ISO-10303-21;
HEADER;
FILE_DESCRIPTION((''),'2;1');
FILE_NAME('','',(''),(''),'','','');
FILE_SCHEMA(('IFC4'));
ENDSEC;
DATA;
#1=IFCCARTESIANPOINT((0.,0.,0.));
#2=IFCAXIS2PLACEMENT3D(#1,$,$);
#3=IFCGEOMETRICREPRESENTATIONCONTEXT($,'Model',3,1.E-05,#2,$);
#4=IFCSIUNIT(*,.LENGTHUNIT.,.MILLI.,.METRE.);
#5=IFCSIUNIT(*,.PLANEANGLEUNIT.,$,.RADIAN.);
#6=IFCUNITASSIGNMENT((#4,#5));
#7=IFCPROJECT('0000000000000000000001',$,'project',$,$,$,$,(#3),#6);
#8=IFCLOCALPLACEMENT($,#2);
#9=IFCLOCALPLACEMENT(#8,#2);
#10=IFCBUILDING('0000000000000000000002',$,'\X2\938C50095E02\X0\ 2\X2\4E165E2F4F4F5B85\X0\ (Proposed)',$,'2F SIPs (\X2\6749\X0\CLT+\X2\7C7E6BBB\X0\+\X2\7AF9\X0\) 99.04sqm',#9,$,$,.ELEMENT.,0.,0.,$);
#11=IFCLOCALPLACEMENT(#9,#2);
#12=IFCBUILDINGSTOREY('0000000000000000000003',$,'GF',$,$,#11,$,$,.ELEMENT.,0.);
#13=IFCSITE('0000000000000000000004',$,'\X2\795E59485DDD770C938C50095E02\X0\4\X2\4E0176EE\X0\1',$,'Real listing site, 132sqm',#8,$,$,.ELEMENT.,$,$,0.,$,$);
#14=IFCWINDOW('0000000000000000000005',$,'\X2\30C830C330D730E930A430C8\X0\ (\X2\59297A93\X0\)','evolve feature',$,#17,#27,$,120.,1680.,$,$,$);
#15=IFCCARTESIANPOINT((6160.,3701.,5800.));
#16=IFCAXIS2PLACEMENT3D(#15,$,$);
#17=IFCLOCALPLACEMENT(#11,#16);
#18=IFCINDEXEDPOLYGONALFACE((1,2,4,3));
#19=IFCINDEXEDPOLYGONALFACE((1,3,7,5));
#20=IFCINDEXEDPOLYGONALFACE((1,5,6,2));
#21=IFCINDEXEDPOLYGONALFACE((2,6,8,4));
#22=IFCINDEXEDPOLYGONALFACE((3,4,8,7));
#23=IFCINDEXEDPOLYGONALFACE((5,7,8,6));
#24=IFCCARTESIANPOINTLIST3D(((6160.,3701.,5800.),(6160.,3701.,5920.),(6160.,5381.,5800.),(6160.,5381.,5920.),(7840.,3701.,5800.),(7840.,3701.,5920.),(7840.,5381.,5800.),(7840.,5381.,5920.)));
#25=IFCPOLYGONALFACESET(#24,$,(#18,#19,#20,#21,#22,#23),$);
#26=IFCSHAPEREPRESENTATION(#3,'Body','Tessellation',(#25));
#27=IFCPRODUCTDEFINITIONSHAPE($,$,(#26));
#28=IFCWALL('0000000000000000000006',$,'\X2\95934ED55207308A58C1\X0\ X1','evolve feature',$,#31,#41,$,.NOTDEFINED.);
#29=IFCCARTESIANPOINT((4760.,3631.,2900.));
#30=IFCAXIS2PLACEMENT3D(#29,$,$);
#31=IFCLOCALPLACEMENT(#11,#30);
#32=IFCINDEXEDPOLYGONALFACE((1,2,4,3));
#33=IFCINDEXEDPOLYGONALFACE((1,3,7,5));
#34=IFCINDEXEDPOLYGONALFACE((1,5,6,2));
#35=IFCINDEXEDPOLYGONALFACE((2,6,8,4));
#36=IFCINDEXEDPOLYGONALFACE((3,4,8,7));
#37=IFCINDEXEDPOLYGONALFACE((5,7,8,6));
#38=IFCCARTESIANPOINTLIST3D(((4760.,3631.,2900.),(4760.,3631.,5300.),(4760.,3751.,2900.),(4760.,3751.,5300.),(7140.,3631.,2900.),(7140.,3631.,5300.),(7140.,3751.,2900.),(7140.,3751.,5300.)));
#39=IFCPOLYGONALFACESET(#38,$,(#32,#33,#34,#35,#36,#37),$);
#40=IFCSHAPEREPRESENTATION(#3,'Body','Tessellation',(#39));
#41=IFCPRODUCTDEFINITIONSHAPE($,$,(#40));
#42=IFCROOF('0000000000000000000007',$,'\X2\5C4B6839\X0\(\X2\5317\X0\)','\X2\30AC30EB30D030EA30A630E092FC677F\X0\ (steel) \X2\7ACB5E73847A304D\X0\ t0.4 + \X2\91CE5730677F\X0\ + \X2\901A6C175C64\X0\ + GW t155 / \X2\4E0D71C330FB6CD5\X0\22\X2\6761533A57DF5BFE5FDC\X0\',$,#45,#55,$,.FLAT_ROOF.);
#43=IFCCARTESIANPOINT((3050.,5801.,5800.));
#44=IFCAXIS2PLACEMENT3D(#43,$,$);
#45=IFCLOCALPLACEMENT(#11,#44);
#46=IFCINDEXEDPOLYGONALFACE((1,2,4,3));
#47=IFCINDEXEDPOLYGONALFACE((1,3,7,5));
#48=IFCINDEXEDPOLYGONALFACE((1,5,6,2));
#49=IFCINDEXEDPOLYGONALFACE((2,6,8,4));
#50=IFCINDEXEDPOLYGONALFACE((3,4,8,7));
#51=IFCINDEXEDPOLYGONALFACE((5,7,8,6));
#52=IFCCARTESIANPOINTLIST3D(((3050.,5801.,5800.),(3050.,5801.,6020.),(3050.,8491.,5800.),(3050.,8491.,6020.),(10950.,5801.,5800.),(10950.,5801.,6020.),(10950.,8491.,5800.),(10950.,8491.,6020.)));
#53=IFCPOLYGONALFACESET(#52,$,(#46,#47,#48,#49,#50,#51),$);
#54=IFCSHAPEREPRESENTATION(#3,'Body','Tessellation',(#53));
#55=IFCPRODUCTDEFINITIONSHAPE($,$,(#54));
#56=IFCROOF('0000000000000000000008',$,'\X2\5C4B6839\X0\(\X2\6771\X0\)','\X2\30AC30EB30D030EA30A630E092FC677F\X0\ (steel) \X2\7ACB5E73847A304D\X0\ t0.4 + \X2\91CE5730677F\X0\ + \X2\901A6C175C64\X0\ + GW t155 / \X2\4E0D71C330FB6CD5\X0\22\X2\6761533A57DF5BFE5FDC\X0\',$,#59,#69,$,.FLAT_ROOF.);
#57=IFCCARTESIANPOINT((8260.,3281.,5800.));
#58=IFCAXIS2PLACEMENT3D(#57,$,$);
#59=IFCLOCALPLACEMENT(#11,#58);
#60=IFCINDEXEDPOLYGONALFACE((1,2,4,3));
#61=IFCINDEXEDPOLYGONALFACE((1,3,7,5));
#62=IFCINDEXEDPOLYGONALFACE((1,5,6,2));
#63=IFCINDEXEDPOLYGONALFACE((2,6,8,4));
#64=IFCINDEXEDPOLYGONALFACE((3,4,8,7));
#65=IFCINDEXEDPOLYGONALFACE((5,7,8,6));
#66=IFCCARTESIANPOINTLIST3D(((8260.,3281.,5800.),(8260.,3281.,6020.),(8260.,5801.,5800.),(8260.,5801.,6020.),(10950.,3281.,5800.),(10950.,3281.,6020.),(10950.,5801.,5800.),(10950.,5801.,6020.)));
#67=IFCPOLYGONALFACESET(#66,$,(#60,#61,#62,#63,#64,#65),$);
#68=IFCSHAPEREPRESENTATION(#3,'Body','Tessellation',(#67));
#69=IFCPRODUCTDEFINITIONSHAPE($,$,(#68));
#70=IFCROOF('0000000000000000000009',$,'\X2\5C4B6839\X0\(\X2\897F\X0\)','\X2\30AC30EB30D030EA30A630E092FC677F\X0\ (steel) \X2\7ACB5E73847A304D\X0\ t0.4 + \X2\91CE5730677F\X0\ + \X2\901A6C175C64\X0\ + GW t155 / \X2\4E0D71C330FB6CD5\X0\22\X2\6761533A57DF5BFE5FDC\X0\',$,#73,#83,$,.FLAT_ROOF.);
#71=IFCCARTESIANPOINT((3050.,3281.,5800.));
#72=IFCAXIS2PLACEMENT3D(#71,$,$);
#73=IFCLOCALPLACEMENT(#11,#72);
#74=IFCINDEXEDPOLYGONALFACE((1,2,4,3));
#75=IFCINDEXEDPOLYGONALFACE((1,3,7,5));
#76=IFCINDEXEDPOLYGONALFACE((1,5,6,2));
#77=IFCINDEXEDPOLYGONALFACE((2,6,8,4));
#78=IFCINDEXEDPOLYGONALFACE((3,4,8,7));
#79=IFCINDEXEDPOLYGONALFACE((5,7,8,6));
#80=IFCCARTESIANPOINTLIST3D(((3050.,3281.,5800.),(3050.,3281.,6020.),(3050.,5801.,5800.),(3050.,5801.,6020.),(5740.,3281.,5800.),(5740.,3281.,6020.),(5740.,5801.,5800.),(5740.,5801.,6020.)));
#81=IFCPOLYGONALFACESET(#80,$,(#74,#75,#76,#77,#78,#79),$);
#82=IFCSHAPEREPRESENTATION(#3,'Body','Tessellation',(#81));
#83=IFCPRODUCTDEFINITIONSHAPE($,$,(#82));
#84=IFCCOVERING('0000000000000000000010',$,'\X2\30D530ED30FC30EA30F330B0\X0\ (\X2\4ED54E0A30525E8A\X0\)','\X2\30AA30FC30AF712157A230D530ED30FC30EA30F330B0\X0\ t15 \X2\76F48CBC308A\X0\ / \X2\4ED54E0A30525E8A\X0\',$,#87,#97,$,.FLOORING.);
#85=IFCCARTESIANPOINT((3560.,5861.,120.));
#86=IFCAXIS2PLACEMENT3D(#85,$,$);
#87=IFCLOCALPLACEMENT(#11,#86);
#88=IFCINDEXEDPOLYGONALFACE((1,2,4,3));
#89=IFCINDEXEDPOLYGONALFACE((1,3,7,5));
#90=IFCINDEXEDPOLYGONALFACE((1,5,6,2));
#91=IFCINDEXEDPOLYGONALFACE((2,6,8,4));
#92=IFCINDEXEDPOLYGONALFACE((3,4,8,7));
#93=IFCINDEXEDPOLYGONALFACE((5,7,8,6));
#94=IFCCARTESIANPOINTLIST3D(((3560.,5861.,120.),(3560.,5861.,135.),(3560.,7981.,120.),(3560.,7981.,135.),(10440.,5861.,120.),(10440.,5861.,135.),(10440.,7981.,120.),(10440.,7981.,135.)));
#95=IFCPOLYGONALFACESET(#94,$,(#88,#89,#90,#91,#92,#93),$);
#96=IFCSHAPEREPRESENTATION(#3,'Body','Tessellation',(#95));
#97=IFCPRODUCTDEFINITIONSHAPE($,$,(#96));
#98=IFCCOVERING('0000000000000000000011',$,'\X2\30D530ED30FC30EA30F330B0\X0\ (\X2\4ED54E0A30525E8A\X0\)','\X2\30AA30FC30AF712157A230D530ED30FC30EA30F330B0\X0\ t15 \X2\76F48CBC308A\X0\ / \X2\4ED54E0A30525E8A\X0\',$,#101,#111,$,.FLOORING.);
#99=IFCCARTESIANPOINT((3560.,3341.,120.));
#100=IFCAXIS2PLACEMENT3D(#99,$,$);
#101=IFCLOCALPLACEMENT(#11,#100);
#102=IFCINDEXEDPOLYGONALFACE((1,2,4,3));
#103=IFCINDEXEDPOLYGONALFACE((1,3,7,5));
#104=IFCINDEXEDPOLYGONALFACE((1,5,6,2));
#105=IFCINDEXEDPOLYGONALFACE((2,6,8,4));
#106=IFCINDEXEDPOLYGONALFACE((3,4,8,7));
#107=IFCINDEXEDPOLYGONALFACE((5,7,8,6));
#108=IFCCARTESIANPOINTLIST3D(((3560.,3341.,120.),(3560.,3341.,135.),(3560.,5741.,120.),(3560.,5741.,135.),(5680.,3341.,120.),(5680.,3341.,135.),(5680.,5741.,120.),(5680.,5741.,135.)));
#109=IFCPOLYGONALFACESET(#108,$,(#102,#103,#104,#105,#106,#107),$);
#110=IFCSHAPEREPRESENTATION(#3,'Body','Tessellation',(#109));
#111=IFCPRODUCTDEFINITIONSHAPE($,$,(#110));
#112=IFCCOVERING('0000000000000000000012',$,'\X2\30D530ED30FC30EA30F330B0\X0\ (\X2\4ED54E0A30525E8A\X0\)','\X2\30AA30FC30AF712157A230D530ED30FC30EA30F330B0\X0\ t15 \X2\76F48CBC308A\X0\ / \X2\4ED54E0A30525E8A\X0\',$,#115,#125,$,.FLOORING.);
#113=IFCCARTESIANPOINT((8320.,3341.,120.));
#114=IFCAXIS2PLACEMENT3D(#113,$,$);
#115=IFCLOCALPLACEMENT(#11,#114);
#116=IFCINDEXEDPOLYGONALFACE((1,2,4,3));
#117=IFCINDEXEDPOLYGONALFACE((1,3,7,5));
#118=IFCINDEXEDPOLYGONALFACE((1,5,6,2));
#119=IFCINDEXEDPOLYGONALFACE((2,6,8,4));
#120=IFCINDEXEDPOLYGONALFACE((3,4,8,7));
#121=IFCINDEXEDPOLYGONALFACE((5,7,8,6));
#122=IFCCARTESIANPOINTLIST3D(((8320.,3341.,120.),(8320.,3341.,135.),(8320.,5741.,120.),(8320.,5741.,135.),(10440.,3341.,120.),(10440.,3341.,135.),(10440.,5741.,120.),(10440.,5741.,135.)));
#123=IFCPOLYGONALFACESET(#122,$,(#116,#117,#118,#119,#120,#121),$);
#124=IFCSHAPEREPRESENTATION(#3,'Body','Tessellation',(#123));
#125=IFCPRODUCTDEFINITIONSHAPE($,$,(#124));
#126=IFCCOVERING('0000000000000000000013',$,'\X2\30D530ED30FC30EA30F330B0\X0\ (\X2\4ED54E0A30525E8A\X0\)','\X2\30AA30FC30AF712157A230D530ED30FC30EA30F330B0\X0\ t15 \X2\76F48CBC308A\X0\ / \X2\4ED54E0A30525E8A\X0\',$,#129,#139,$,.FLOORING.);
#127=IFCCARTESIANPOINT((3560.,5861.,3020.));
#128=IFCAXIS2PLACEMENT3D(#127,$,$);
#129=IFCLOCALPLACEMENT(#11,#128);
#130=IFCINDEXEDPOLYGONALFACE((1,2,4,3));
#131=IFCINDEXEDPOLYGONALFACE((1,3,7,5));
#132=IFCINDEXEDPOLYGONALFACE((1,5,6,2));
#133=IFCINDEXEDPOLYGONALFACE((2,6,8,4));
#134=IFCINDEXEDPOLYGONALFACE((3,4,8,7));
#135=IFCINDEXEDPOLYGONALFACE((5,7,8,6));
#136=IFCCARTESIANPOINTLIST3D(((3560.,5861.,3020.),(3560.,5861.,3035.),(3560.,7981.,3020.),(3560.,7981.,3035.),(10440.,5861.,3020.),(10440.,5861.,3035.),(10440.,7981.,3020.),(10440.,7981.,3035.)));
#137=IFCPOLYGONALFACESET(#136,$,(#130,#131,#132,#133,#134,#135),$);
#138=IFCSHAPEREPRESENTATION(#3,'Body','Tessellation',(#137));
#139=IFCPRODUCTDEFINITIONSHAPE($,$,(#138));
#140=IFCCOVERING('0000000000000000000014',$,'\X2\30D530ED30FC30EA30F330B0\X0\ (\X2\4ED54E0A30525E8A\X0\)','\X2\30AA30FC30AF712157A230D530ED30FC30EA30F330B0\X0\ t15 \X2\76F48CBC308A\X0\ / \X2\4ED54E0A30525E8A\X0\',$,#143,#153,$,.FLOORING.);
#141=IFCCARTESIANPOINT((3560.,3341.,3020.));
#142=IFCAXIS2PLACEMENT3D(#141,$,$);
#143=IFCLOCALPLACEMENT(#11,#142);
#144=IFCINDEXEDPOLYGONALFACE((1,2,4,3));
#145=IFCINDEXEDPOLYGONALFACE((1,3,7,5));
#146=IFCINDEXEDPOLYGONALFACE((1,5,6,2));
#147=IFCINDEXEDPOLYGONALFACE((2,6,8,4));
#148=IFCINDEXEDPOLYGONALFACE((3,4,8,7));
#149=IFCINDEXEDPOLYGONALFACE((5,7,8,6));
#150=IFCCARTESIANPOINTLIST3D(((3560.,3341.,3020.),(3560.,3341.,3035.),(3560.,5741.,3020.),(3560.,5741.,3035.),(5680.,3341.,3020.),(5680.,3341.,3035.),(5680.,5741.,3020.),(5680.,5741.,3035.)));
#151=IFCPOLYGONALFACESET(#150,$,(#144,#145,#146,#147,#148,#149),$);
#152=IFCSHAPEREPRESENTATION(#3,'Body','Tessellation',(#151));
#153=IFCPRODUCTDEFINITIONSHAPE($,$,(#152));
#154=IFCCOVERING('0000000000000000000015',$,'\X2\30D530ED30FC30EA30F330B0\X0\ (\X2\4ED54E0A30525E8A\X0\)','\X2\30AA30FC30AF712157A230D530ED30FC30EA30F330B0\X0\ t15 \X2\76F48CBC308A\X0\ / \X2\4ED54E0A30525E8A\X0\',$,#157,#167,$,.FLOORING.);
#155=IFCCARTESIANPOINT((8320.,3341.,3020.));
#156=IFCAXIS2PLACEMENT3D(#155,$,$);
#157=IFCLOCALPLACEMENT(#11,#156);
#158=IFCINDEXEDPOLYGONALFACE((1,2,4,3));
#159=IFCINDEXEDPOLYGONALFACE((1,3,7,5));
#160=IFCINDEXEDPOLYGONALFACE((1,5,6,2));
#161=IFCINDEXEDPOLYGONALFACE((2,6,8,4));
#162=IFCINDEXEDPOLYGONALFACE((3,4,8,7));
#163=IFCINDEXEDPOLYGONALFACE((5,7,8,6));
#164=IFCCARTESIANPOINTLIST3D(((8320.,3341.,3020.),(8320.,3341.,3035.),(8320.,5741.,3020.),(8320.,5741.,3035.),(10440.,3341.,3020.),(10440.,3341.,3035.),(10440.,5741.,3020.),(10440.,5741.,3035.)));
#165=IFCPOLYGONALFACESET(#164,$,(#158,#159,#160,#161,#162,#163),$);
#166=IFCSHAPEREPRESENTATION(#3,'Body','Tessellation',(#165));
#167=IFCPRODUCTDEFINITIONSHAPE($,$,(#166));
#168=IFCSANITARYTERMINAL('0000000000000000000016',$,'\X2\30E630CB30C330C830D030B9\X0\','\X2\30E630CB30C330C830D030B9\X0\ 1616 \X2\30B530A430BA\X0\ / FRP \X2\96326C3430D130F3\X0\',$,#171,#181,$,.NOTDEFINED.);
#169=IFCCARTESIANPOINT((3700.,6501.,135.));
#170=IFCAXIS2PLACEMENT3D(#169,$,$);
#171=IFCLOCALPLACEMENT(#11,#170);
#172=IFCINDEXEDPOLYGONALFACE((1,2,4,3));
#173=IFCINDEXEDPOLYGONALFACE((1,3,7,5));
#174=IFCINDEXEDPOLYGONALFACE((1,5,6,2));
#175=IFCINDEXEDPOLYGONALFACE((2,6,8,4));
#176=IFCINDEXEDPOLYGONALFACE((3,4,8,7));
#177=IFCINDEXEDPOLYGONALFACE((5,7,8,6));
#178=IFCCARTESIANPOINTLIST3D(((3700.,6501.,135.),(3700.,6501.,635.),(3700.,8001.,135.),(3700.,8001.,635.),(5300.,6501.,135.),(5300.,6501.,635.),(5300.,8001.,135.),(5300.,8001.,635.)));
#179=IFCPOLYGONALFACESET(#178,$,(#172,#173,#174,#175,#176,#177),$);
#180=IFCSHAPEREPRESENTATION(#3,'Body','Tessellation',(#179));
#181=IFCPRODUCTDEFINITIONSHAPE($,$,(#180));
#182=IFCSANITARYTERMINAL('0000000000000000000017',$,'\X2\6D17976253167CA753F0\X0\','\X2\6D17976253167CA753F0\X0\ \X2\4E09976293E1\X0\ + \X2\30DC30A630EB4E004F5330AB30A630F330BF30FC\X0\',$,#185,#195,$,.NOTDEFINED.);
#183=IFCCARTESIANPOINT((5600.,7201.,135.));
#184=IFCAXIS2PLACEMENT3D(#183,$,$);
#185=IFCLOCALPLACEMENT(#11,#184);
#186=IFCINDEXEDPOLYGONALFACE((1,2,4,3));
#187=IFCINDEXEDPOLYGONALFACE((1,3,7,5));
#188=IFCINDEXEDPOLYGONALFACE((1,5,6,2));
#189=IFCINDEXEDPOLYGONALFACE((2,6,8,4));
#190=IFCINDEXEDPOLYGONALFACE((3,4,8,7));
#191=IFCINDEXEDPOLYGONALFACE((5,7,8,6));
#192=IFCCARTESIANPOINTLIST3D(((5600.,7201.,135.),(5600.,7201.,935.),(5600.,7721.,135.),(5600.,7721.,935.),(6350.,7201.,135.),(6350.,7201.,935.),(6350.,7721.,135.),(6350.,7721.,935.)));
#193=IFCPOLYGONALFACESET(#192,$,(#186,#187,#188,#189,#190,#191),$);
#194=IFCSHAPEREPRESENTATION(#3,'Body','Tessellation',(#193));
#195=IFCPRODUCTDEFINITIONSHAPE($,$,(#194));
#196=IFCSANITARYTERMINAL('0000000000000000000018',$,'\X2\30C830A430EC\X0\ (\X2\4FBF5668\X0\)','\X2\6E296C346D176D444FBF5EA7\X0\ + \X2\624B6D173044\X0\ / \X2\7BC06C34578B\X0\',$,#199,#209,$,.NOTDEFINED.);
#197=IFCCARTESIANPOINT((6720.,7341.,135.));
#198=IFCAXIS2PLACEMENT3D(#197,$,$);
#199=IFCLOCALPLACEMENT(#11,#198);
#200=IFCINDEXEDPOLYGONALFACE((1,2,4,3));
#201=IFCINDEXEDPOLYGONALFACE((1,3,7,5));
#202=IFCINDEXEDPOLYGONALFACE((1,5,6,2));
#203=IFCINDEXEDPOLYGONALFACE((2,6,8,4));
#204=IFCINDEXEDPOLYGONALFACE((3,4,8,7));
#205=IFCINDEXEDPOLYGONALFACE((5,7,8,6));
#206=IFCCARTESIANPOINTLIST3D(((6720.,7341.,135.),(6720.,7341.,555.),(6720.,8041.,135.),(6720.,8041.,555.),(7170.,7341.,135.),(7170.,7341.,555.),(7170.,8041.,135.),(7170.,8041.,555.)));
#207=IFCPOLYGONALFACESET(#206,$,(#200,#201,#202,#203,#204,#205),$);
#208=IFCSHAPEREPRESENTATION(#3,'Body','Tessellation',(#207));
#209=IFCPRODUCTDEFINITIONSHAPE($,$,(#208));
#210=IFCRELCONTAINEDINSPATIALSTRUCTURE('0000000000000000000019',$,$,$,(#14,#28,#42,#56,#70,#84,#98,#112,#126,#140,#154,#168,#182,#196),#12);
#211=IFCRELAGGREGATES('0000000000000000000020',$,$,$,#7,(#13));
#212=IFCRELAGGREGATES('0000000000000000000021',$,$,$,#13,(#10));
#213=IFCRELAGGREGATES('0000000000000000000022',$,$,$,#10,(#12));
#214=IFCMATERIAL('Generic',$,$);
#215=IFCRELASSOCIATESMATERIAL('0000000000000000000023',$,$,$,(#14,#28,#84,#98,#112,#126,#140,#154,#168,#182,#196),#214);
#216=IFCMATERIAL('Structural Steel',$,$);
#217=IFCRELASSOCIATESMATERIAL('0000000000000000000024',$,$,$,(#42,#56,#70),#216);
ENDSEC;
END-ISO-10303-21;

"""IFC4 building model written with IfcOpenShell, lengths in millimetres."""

from ifc_helpers import new_model, si_unit, frame, frame_2d, origin, place, context, project, spatial, rectangle, extrude, material, element, save


model = new_model("IFC4")

# Units and contexts
model_context = context("Model", 3, precision=1e-05, world=origin())
ifc_project = project(units=[si_unit("LENGTHUNIT", "METRE", prefix="MILLI"), si_unit("PLANEANGLEUNIT", "RADIAN")], contexts=[model_context])

# Site, building, storey
site_placement = place(None, origin())
site = spatial("IfcSite", under=ifc_project, at=site_placement, Name="神奈川県鎌倉市4丁目1", ObjectType="Real listing site, 132sqm", CompositionType="ELEMENT", RefElevation=0.0)
building_placement = place(site_placement, origin())
building = spatial("IfcBuilding", under=site, at=building_placement, Name="鎌倉市 2世帯住宅 (Proposed)", ObjectType="2F SIPs (杉CLT+籾殻+竹) 99.04sqm", CompositionType="ELEMENT", ElevationOfRefHeight=0.0, ElevationOfTerrain=0.0)
storey_placement = place(building_placement, origin())
storey = spatial("IfcBuildingStorey", under=building, at=storey_placement, Name="GF", CompositionType="ELEMENT", Elevation=0.0)

# Window
ifc_material_1 = material(Name="Generic")
window_1_placement = place(storey_placement, frame((6160.0, 3701.0, 5800.0)))
element("IfcWindow", 1, at=window_1_placement, inside=storey, material=ifc_material_1, Name="トップライト (天窓)", Description="evolve feature", OverallHeight=120.0, OverallWidth=1680.0, context=model_context, shape_type="SweptSolid", body=[
    extrude(rectangle(XDim=1680.0, YDim=1680.0, at=frame_2d((840.0, 840.0))), frame((6160.0, 3701.0, 5800.0)), (0.0, 0.0, 1.0), 120.0),
])

# Wall
wall_1_placement = place(storey_placement, frame((4760.0, 3631.0, 2900.0)))
element("IfcWall", 2, at=wall_1_placement, inside=storey, material=ifc_material_1, Name="間仕切り壁 X1", Description="evolve feature", PredefinedType="NOTDEFINED", context=model_context, shape_type="SweptSolid", body=[
    extrude(rectangle(XDim=2380.0, YDim=120.0, at=frame_2d((1190.0, 60.0))), frame((4760.0, 3631.0, 2900.0)), (0.0, 0.0, 1.0), 2400.0),
])

# Roofs
ifc_material_2 = material(Name="Structural Steel")
roof_1_placement = place(storey_placement, frame((3050.0, 5801.0, 5800.0)))
element("IfcRoof", 3, at=roof_1_placement, inside=storey, material=ifc_material_2, Name="屋根(北)", Description="ガルバリウム鋼板 (steel) 立平葺き t0.4 + 野地板 + 通気層 + GW t155 / 不燃・法22条区域対応", PredefinedType="FLAT_ROOF", context=model_context, shape_type="SweptSolid", body=[
    extrude(rectangle(XDim=7900.0, YDim=2690.0, at=frame_2d((3950.0, 1345.0))), frame((3050.0, 5801.0, 5800.0)), (0.0, 0.0, 1.0), 220.0),
])
roof_2_placement = place(storey_placement, frame((8260.0, 3281.0, 5800.0)))
element("IfcRoof", 4, at=roof_2_placement, inside=storey, material=ifc_material_2, Name="屋根(東)", Description="ガルバリウム鋼板 (steel) 立平葺き t0.4 + 野地板 + 通気層 + GW t155 / 不燃・法22条区域対応", PredefinedType="FLAT_ROOF", context=model_context, shape_type="SweptSolid", body=[
    extrude(rectangle(XDim=2690.0, YDim=2520.0, at=frame_2d((1345.0, 1260.0))), frame((8260.0, 3281.0, 5800.0)), (0.0, 0.0, 1.0), 220.0),
])
roof_3_placement = place(storey_placement, frame((3050.0, 3281.0, 5800.0)))
element("IfcRoof", 5, at=roof_3_placement, inside=storey, material=ifc_material_2, Name="屋根(西)", Description="ガルバリウム鋼板 (steel) 立平葺き t0.4 + 野地板 + 通気層 + GW t155 / 不燃・法22条区域対応", PredefinedType="FLAT_ROOF", context=model_context, shape_type="SweptSolid", body=[
    extrude(rectangle(XDim=2690.0, YDim=2520.0, at=frame_2d((1345.0, 1260.0))), frame((3050.0, 3281.0, 5800.0)), (0.0, 0.0, 1.0), 220.0),
])

# Coverings
covering_1_placement = place(storey_placement, frame((3560.0, 5861.0, 120.0)))
element("IfcCovering", 6, at=covering_1_placement, inside=storey, material=ifc_material_1, Name="フローリング (仕上げ床)", Description="オーク無垢フローリング t15 直貼り / 仕上げ床", PredefinedType="FLOORING", context=model_context, shape_type="SweptSolid", body=[
    extrude(rectangle(XDim=6880.0, YDim=2120.0, at=frame_2d((3440.0, 1060.0))), frame((3560.0, 5861.0, 120.0)), (0.0, 0.0, 1.0), 15.0),
])
covering_2_placement = place(storey_placement, frame((3560.0, 3341.0, 120.0)))
element("IfcCovering", 7, at=covering_2_placement, inside=storey, material=ifc_material_1, Name="フローリング (仕上げ床)", Description="オーク無垢フローリング t15 直貼り / 仕上げ床", PredefinedType="FLOORING", context=model_context, shape_type="SweptSolid", body=[
    extrude(rectangle(XDim=2120.0, YDim=2400.0, at=frame_2d((1060.0, 1200.0))), frame((3560.0, 3341.0, 120.0)), (0.0, 0.0, 1.0), 15.0),
])
covering_3_placement = place(storey_placement, frame((8320.0, 3341.0, 120.0)))
element("IfcCovering", 8, at=covering_3_placement, inside=storey, material=ifc_material_1, Name="フローリング (仕上げ床)", Description="オーク無垢フローリング t15 直貼り / 仕上げ床", PredefinedType="FLOORING", context=model_context, shape_type="SweptSolid", body=[
    extrude(rectangle(XDim=2120.0, YDim=2400.0, at=frame_2d((1060.0, 1200.0))), frame((8320.0, 3341.0, 120.0)), (0.0, 0.0, 1.0), 15.0),
])
covering_4_placement = place(storey_placement, frame((3560.0, 5861.0, 3020.0)))
element("IfcCovering", 9, at=covering_4_placement, inside=storey, material=ifc_material_1, Name="フローリング (仕上げ床)", Description="オーク無垢フローリング t15 直貼り / 仕上げ床", PredefinedType="FLOORING", context=model_context, shape_type="SweptSolid", body=[
    extrude(rectangle(XDim=6880.0, YDim=2120.0, at=frame_2d((3440.0, 1060.0))), frame((3560.0, 5861.0, 3020.0)), (0.0, 0.0, 1.0), 15.0),
])
covering_5_placement = place(storey_placement, frame((3560.0, 3341.0, 3020.0)))
element("IfcCovering", 10, at=covering_5_placement, inside=storey, material=ifc_material_1, Name="フローリング (仕上げ床)", Description="オーク無垢フローリング t15 直貼り / 仕上げ床", PredefinedType="FLOORING", context=model_context, shape_type="SweptSolid", body=[
    extrude(rectangle(XDim=2120.0, YDim=2400.0, at=frame_2d((1060.0, 1200.0))), frame((3560.0, 3341.0, 3020.0)), (0.0, 0.0, 1.0), 15.0),
])
covering_6_placement = place(storey_placement, frame((8320.0, 3341.0, 3020.0)))
element("IfcCovering", 11, at=covering_6_placement, inside=storey, material=ifc_material_1, Name="フローリング (仕上げ床)", Description="オーク無垢フローリング t15 直貼り / 仕上げ床", PredefinedType="FLOORING", context=model_context, shape_type="SweptSolid", body=[
    extrude(rectangle(XDim=2120.0, YDim=2400.0, at=frame_2d((1060.0, 1200.0))), frame((8320.0, 3341.0, 3020.0)), (0.0, 0.0, 1.0), 15.0),
])

# Sanitary terminals
sanitary_terminal_1_placement = place(storey_placement, frame((3700.0, 6501.0, 135.0)))
element("IfcSanitaryTerminal", 12, at=sanitary_terminal_1_placement, inside=storey, material=ifc_material_1, Name="ユニットバス", Description="ユニットバス 1616 サイズ / FRP 防水パン", PredefinedType="NOTDEFINED", context=model_context, shape_type="SweptSolid", body=[
    extrude(rectangle(XDim=1600.0, YDim=1500.0, at=frame_2d((800.0, 750.0))), frame((3700.0, 6501.0, 135.0)), (0.0, 0.0, 1.0), 500.0),
])
sanitary_terminal_2_placement = place(storey_placement, frame((5600.0, 7201.0, 135.0)))
element("IfcSanitaryTerminal", 13, at=sanitary_terminal_2_placement, inside=storey, material=ifc_material_1, Name="洗面化粧台", Description="洗面化粧台 三面鏡 + ボウル一体カウンター", PredefinedType="NOTDEFINED", context=model_context, shape_type="SweptSolid", body=[
    extrude(rectangle(XDim=750.0, YDim=520.0, at=frame_2d((375.0, 260.0))), frame((5600.0, 7201.0, 135.0)), (0.0, 0.0, 1.0), 800.0),
])
sanitary_terminal_3_placement = place(storey_placement, frame((6720.0, 7341.0, 135.0)))
element("IfcSanitaryTerminal", 14, at=sanitary_terminal_3_placement, inside=storey, material=ifc_material_1, Name="トイレ (便器)", Description="温水洗浄便座 + 手洗い / 節水型", PredefinedType="NOTDEFINED", context=model_context, shape_type="SweptSolid", body=[
    extrude(rectangle(XDim=450.0, YDim=700.0, at=frame_2d((225.0, 350.0))), frame((6720.0, 7341.0, 135.0)), (0.0, 0.0, 1.0), 420.0),
])

save(model, "model.ifc")
